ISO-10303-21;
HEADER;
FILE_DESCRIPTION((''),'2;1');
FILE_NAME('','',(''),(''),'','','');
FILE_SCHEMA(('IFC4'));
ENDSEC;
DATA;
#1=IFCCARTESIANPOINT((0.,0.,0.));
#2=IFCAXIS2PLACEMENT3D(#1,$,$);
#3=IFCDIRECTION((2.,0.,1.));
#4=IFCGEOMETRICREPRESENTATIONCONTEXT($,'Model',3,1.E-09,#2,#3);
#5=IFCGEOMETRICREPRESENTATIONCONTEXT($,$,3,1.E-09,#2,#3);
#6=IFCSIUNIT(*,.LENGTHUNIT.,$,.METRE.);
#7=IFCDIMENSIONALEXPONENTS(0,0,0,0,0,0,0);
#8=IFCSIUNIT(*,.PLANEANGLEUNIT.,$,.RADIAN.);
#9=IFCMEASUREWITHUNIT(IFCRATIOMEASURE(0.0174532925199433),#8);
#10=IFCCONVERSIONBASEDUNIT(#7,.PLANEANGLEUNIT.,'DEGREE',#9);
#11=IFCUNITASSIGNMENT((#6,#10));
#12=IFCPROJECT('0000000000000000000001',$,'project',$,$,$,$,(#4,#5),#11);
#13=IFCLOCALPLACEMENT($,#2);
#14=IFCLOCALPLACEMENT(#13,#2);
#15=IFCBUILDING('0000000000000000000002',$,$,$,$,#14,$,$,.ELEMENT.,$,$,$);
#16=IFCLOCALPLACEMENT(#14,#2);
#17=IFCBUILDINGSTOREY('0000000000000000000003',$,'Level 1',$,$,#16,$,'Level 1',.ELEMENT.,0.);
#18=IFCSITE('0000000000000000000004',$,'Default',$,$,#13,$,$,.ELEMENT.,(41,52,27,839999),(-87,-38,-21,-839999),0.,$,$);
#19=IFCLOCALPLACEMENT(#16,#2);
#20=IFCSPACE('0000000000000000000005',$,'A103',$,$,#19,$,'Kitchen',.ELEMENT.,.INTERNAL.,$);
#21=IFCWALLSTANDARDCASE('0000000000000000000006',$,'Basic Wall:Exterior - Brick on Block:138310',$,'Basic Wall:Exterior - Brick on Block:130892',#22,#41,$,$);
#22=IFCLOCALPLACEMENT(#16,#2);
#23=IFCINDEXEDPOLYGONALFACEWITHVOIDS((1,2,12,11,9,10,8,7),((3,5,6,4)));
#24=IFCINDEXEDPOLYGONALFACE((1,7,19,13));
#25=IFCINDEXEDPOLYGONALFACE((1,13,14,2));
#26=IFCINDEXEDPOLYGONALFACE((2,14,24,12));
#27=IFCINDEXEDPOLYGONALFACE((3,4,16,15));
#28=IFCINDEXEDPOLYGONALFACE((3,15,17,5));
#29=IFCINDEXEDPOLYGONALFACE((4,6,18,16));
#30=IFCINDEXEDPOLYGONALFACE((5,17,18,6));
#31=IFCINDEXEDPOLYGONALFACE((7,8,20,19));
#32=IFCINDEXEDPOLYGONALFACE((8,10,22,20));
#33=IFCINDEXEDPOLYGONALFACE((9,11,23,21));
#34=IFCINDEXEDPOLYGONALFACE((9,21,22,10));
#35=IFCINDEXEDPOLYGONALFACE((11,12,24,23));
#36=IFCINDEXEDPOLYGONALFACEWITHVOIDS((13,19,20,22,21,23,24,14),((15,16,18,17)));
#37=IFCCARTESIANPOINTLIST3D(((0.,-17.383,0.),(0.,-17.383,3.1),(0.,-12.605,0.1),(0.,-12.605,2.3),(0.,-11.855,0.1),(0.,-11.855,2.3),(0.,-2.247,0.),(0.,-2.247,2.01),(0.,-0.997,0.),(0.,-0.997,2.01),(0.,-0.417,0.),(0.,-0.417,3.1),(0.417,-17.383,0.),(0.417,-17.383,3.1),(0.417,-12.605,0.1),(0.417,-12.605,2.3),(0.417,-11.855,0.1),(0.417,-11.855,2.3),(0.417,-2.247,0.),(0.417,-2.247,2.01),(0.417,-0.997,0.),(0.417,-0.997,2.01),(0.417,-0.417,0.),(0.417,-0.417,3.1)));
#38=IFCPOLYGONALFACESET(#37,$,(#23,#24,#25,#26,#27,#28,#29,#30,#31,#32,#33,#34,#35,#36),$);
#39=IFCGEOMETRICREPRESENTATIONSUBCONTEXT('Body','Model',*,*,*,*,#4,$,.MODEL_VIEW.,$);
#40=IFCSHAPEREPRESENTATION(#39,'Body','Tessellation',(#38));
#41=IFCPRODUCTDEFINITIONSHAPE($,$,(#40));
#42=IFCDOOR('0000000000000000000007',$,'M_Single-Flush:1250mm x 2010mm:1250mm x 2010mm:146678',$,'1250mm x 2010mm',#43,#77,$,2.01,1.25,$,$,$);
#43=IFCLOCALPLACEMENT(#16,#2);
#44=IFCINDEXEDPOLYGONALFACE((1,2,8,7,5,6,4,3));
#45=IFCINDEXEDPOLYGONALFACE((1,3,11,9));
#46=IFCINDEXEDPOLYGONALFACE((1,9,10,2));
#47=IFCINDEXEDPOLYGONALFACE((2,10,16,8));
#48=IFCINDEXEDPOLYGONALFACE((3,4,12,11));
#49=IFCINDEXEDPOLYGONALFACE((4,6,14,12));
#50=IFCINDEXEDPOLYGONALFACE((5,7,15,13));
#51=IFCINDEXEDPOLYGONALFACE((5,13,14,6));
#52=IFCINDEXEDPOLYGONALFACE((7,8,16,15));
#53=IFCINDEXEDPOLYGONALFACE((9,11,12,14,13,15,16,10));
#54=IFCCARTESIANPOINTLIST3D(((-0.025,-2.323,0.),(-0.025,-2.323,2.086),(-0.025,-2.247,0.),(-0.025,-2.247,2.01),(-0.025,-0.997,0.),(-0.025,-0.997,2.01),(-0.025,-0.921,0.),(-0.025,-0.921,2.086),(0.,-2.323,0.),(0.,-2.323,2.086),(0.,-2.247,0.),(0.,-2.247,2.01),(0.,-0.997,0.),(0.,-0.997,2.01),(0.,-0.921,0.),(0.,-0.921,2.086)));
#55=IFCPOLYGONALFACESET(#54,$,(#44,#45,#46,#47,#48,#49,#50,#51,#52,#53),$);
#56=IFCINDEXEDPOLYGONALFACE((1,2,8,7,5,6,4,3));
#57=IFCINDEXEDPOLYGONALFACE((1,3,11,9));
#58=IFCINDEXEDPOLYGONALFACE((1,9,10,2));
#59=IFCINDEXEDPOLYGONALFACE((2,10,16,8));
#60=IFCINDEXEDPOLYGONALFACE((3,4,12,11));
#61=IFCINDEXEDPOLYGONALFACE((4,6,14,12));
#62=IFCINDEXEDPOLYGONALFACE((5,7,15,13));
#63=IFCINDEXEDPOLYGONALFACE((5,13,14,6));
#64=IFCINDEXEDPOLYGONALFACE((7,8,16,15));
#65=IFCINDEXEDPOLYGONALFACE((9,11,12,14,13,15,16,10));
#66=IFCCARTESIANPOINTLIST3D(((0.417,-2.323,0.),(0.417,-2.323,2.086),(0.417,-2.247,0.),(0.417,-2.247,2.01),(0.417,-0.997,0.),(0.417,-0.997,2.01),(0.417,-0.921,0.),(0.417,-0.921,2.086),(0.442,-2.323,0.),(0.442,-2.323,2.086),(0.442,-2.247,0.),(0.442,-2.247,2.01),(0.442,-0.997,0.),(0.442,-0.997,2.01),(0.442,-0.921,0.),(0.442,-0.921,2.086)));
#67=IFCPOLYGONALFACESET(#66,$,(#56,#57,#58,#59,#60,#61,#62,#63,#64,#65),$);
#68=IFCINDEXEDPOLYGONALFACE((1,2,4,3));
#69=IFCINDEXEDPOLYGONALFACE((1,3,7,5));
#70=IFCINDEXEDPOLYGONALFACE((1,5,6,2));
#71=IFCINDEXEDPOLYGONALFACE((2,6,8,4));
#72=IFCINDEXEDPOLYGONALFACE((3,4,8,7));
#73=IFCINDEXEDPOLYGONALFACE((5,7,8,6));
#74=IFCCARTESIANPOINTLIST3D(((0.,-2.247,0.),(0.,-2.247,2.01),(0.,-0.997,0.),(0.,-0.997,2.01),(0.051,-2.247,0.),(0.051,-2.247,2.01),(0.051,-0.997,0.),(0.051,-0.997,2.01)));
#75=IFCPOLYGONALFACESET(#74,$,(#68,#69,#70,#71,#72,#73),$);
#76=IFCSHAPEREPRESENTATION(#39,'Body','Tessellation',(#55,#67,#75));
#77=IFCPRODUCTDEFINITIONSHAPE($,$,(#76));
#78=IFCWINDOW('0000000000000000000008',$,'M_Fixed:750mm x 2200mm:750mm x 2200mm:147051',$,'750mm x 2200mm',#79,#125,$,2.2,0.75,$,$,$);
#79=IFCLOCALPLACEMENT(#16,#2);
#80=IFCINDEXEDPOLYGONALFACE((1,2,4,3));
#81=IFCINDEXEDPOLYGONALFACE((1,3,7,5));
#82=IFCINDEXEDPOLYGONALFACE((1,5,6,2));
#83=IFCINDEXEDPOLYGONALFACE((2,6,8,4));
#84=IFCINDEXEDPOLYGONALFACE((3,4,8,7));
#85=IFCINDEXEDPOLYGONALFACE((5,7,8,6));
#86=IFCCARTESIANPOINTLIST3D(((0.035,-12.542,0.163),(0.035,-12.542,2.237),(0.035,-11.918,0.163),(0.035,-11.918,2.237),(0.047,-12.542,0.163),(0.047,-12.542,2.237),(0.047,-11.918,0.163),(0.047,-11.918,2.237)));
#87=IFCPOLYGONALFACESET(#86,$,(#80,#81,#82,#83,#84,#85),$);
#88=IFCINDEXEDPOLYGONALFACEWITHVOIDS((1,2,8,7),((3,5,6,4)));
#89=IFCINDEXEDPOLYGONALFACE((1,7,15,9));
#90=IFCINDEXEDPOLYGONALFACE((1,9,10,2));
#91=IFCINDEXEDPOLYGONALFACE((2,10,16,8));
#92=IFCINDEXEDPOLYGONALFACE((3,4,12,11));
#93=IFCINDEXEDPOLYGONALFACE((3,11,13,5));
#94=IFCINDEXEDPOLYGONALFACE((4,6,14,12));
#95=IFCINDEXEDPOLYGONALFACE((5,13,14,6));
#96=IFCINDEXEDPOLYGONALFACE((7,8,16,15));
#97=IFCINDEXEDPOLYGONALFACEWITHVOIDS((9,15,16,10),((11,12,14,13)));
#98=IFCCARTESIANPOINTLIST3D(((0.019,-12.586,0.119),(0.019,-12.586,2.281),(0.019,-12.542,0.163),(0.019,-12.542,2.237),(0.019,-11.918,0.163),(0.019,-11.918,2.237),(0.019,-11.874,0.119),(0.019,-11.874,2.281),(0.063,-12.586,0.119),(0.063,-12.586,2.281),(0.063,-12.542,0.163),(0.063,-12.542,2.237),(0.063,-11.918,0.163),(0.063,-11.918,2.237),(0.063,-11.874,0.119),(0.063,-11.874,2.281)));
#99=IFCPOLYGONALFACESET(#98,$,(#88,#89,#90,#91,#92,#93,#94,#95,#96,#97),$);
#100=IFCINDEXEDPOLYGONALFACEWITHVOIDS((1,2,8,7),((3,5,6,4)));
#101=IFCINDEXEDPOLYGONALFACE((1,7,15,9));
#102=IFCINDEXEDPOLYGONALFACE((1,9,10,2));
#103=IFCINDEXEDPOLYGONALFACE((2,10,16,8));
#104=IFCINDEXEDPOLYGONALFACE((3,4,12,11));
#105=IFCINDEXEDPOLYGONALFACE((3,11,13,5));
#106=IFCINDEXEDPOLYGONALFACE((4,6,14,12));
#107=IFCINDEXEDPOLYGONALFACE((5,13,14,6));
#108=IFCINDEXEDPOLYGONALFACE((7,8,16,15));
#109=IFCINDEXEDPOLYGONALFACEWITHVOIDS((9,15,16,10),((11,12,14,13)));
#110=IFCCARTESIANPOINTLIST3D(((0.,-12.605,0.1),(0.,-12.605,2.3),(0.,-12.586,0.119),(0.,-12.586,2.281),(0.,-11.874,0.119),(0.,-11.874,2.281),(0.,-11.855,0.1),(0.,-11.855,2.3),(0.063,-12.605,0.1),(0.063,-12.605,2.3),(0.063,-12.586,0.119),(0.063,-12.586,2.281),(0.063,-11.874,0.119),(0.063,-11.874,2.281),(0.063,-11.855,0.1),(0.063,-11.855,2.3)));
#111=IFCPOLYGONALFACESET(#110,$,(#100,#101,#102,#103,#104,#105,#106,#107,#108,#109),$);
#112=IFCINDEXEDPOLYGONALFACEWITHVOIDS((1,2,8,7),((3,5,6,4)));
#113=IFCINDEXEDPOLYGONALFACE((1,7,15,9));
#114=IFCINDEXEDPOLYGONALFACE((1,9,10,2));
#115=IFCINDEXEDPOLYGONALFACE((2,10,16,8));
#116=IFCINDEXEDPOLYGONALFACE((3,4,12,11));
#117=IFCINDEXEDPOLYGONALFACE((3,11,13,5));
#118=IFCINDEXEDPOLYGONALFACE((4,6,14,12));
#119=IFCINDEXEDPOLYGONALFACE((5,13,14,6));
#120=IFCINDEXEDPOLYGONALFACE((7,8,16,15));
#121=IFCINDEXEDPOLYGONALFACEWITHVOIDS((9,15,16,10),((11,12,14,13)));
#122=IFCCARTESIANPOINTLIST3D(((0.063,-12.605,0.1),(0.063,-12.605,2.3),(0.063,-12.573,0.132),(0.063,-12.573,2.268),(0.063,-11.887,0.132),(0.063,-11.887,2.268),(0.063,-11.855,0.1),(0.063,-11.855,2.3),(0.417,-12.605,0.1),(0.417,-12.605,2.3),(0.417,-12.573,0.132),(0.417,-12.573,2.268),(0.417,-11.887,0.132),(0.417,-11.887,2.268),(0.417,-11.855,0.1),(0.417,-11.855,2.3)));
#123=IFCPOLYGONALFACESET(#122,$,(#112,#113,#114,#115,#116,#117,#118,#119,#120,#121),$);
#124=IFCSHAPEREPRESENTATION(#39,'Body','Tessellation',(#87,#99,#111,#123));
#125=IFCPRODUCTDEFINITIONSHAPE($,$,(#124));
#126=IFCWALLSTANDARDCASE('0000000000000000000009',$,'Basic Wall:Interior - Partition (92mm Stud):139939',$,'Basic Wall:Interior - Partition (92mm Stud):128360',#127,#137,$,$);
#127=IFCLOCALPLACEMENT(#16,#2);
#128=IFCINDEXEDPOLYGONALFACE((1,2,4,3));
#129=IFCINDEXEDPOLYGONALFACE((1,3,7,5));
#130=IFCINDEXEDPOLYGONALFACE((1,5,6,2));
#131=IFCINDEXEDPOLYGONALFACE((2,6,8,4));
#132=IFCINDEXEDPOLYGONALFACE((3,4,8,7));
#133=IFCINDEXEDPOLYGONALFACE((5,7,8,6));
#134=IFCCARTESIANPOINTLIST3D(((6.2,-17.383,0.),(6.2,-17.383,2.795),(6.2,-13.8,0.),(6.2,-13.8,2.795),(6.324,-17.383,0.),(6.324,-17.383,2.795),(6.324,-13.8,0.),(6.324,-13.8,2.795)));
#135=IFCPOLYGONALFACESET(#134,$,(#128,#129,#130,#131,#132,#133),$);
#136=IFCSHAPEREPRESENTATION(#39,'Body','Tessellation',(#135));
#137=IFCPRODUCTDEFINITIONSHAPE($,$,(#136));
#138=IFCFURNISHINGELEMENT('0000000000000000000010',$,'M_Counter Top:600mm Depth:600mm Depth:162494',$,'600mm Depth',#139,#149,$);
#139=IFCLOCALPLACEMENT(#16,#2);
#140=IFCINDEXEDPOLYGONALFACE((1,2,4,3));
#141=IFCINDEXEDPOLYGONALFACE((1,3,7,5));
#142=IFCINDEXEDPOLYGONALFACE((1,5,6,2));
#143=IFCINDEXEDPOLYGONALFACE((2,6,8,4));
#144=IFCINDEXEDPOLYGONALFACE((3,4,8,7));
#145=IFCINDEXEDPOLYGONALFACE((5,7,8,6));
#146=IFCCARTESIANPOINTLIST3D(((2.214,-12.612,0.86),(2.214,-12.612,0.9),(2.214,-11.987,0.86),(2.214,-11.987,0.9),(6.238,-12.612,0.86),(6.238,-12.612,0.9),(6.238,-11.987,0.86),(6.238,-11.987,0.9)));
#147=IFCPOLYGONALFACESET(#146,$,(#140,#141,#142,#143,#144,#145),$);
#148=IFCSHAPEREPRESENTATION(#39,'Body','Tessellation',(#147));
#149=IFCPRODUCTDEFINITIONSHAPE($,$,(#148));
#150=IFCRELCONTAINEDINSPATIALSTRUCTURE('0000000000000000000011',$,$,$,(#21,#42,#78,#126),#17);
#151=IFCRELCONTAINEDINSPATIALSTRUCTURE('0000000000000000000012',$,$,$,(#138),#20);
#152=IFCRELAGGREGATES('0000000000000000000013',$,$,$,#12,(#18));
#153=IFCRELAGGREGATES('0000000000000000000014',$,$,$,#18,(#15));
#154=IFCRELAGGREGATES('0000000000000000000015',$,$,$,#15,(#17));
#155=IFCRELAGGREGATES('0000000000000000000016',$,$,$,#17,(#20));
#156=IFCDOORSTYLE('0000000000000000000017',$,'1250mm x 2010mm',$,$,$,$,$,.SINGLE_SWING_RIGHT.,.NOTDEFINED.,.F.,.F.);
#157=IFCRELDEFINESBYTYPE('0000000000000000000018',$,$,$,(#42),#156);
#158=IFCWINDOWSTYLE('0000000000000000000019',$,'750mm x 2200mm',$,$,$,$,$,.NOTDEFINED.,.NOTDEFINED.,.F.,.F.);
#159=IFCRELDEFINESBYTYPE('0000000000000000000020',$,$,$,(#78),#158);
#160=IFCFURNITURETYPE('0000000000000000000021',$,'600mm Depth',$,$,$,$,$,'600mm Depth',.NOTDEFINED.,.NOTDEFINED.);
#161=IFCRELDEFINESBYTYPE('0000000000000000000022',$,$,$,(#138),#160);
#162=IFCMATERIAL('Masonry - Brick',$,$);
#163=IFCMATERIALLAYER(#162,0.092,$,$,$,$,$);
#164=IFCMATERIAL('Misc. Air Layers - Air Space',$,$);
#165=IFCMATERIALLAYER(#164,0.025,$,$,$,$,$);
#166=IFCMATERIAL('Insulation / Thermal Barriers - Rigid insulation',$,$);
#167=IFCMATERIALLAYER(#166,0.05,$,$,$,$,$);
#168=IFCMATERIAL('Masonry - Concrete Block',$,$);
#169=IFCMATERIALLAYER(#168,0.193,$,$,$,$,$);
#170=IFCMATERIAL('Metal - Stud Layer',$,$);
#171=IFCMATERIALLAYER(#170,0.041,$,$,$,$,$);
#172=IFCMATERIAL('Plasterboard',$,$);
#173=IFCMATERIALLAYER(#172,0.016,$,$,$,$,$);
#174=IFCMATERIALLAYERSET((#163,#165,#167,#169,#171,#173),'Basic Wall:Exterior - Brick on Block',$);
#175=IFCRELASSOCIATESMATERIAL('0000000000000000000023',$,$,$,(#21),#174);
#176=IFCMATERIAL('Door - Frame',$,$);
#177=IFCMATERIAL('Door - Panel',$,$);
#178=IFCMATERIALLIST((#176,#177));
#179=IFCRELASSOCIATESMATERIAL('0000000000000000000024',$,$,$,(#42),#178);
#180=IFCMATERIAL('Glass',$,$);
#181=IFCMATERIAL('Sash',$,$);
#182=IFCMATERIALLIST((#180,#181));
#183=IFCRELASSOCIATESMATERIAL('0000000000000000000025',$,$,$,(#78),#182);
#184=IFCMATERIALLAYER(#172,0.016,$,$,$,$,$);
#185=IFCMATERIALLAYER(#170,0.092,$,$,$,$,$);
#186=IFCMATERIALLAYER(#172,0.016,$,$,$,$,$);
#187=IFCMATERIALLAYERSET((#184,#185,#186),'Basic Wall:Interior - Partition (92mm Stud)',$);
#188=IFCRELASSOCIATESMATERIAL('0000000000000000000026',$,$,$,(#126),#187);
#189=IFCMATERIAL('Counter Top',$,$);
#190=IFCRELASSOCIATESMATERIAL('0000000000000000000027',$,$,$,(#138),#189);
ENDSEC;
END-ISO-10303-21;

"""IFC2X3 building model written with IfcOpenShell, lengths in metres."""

from ifc_helpers import new_model, entity, si_unit, converted_unit, direction, frame, frame_2d, origin, origin_2d_with_axis, place, context, subcontext, project, spatial, polyline, rectangle, outline, extrude, source, transform, mapped, material, material_list, layer, layer_set, layer_usage, type_object, type_shapes, element, fill, save


model = new_model("IFC2X3")

# Units and contexts
model_context = context("Model", 3, precision=1e-09, world=origin(), true_north=direction((2.0, 0.0, 1.0)))
context_of_model = context(None, 3, precision=1e-09, world=origin(), true_north=direction((2.0, 0.0, 1.0)))
body_context = subcontext(model_context, "Body", "Model", "MODEL_VIEW")
ifc_project = project(units=[si_unit("LENGTHUNIT", "METRE"), converted_unit("PLANEANGLEUNIT", "DEGREE", entity("IfcRatioMeasure", 0.0174532925199433), si_unit("PLANEANGLEUNIT", "RADIAN"), dimensions=[0, 0, 0, 0, 0, 0, 0])], contexts=[model_context, context_of_model])

# Site, building, storey
site_placement = place(None, origin())
site = spatial("IfcSite", under=ifc_project, at=site_placement, Name="Default", CompositionType="ELEMENT", RefLatitude=(41, 52, 27, 839999), RefLongitude=(-87, -38, -21, -839999), RefElevation=0.0)
building_placement = place(site_placement, origin())
building = spatial("IfcBuilding", under=site, at=building_placement, CompositionType="ELEMENT")
storey_placement = place(building_placement, origin())
storey = spatial("IfcBuildingStorey", under=building, at=storey_placement, Name="Level 1", LongName="Level 1", CompositionType="ELEMENT", Elevation=0.0)

# Shared definitions
ifc_material_1 = material(Name="Masonry - Brick")
ifc_layer_1 = layer(ifc_material_1, 0.092)
ifc_material_2 = material(Name="Misc. Air Layers - Air Space")
ifc_layer_2 = layer(ifc_material_2, 0.025)
ifc_material_3 = material(Name="Insulation / Thermal Barriers - Rigid insulation")
ifc_layer_3 = layer(ifc_material_3, 0.05)
ifc_material_4 = material(Name="Masonry - Concrete Block")
ifc_layer_4 = layer(ifc_material_4, 0.193)
ifc_material_5 = material(Name="Metal - Stud Layer")
ifc_layer_5 = layer(ifc_material_5, 0.041)
ifc_material_6 = material(Name="Plasterboard")
ifc_layer_6 = layer(ifc_material_6, 0.016)
ifc_layer_set_1 = layer_set([ifc_layer_1, ifc_layer_2, ifc_layer_3, ifc_layer_4, ifc_layer_5, ifc_layer_6], Name="Basic Wall:Exterior - Brick on Block")
ifc_material_7 = material(Name="Glass")
ifc_material_8 = material(Name="Sash")
ifc_material_9 = material(Name="Door - Frame")
ifc_material_10 = material(Name="Door - Panel")

# Wall, openings, door, window
ifc_layer_usage_1 = layer_usage(ifc_layer_set_1, "AXIS2", "NEGATIVE", 0.2085)
wall_1_placement = place(storey_placement, frame((0.2085, -17.383, 0.0), z_axis=(0.0, 0.0, 1.0), x_axis=(0.0, 1.0, 0.0)))
wall_1 = element("IfcWallStandardCase", 1, at=wall_1_placement, inside=storey, material=ifc_layer_usage_1, Name="Basic Wall:Exterior - Brick on Block:138310", ObjectType="Basic Wall:Exterior - Brick on Block:130892", context=body_context, shape_type="SweptSolid", body=[
    extrude(rectangle(XDim=16.966, YDim=0.417, at=frame_2d((8.483, 0.0), x_axis=(-1.0, 0.0))), origin(), (0.0, 0.0, 1.0), 3.1),
])
opening_1_placement = place(wall_1_placement, frame((15.136, -0.2085, 0.0)))
opening_1 = element("IfcOpeningElement", 2, at=opening_1_placement, cuts=wall_1, ObjectType="Opening", context=body_context, shape_type="SweptSolid", body=[
    extrude(rectangle(XDim=1.25, YDim=2.01, at=frame_2d((1.005, 0.625), x_axis=(0.0, 1.0))), frame((0.0, 0.0, 0.0), z_axis=(0.0, 1.0, 0.0), x_axis=(0.0, 0.0, 1.0)), (0.0, 0.0, 1.0), 0.417),
])
opening_2_placement = place(wall_1_placement, frame((4.778, -0.2085, 0.1)))
opening_2 = element("IfcOpeningElement", 3, at=opening_2_placement, cuts=wall_1, ObjectType="Opening", context=body_context, shape_type="SweptSolid", body=[
    extrude(rectangle(XDim=2.2, YDim=0.75, at=frame_2d((1.1, 0.375), x_axis=(1.0, 0.0))), frame((0.0, 0.0, 0.0), z_axis=(0.0, 1.0, 0.0), x_axis=(0.0, 0.0, 1.0)), (0.0, 0.0, 1.0), 0.417),
])
ifc_material_list_1 = material_list([ifc_material_9, ifc_material_10])
door_style_1 = type_object("IfcDoorStyle", Name="1250mm x 2010mm", ConstructionType="NOTDEFINED", OperationType="SINGLE_SWING_RIGHT", ParameterTakesPrecedence=False, Sizeable=False)
shared_shape_1 = source(origin(), body_context, "Body", "SweptSolid", [
    extrude(outline(polyline([(-0.701, -1.062), (0.701, -1.062), (0.701, 1.024), (0.625, 1.024), (0.625, -0.986), (-0.625, -0.986), (-0.625, 1.024), (-0.701, 1.024), (-0.701, -1.062)])), frame((0.625, 0.417, 1.024), z_axis=(0.0, 1.0, 0.0), x_axis=(1.0, 0.0, 0.0)), (0.0, 0.0, 1.0), 0.025),
    extrude(outline(polyline([(-1.062, -0.701), (1.024, -0.701), (1.024, -0.625), (-0.986, -0.625), (-0.986, 0.625), (1.024, 0.625), (1.024, 0.701), (-1.062, 0.701), (-1.062, -0.701)])), frame((0.625, -0.025, 1.024), z_axis=(0.0, 1.0, 0.0), x_axis=(0.0, 0.0, -1.0)), (0.0, 0.0, 1.0), 0.025),
    extrude(rectangle(XDim=0.051, YDim=1.25, at=frame_2d((0.0, 0.0), x_axis=(1.0, 0.0))), frame((0.625, 0.3915, 0.0), z_axis=(0.0, 0.0, 1.0), x_axis=(0.0, 1.0, 0.0)), (0.0, 0.0, 1.0), 2.01),
])
type_shapes(door_style_1, [shared_shape_1])
door_1_placement = place(opening_1_placement, origin())
door_1 = element("IfcDoor", 4, at=door_1_placement, inside=storey, type_object=door_style_1, material=ifc_material_list_1, Name="M_Single-Flush:1250mm x 2010mm:1250mm x 2010mm:146678", ObjectType="1250mm x 2010mm", OverallHeight=2.01, OverallWidth=1.25, context=body_context, shape_type="MappedRepresentation", body=[
    mapped(shared_shape_1, transform((0.0, 0.0, 0.0), scale=1.0)),
])
fill(opening_1, door_1)
ifc_material_list_2 = material_list([ifc_material_7, ifc_material_8])
window_style_1 = type_object("IfcWindowStyle", Name="750mm x 2200mm", ConstructionType="NOTDEFINED", OperationType="NOTDEFINED", ParameterTakesPrecedence=False, Sizeable=False)
shared_shape_2 = source(origin(), body_context, "Body", "SweptSolid", [
    extrude(rectangle(XDim=0.012, YDim=0.624, at=origin_2d_with_axis()), frame((0.375, 0.376, 0.063), z_axis=(0.0, 0.0, 1.0), x_axis=(0.0, -1.0, 0.0)), (0.0, 0.0, 1.0), 2.074),
    extrude(outline(polyline([(-0.356, -1.081), (0.356, -1.081), (0.356, 1.081), (-0.356, 1.081), (-0.356, -1.081)]), holes=[polyline([(-0.312, -1.037), (-0.312, 1.037), (0.312, 1.037), (0.312, -1.037), (-0.312, -1.037)])]), frame((0.375, 0.354, 1.1), z_axis=(0.0, 1.0, 0.0), x_axis=(1.0, 0.0, 0.0)), (0.0, 0.0, 1.0), 0.044),
    extrude(outline(polyline([(-0.375, -1.1), (0.375, -1.1), (0.375, 1.1), (-0.375, 1.1), (-0.375, -1.1)]), holes=[polyline([(-0.356, -1.081), (-0.356, 1.081), (0.356, 1.081), (0.356, -1.081), (-0.356, -1.081)])]), frame((0.375, 0.354, 1.1), z_axis=(0.0, 1.0, 0.0), x_axis=(1.0, 0.0, 0.0)), (0.0, 0.0, 1.0), 0.063),
    extrude(outline(polyline([(-0.375, -1.1), (0.375, -1.1), (0.375, 1.1), (-0.375, 1.1), (-0.375, -1.1)]), holes=[polyline([(-0.343, -1.068), (-0.343, 1.068), (0.343, 1.068), (0.343, -1.068), (-0.343, -1.068)])]), frame((0.375, 0.0, 1.1), z_axis=(0.0, 1.0, 0.0), x_axis=(1.0, 0.0, 0.0)), (0.0, 0.0, 1.0), 0.354),
])
type_shapes(window_style_1, [shared_shape_2])
window_1_placement = place(opening_2_placement, origin())
window_1 = element("IfcWindow", 5, at=window_1_placement, inside=storey, type_object=window_style_1, material=ifc_material_list_2, Name="M_Fixed:750mm x 2200mm:750mm x 2200mm:147051", ObjectType="750mm x 2200mm", OverallHeight=2.2, OverallWidth=0.75, context=body_context, shape_type="MappedRepresentation", body=[
    mapped(shared_shape_2, transform((0.0, 0.0, 0.0), scale=1.0)),
])
fill(opening_2, window_1)

# Wall
ifc_layer_7 = layer(ifc_material_6, 0.016)
ifc_layer_8 = layer(ifc_material_5, 0.092)
ifc_layer_9 = layer(ifc_material_6, 0.016)
ifc_layer_set_2 = layer_set([ifc_layer_7, ifc_layer_8, ifc_layer_9], Name="Basic Wall:Interior - Partition (92mm Stud)")
ifc_layer_usage_2 = layer_usage(ifc_layer_set_2, "AXIS2", "NEGATIVE", 0.062)
wall_2_placement = place(storey_placement, frame((6.262, -13.8, 0.0), z_axis=(0.0, 0.0, 1.0), x_axis=(0.0, -1.0, 0.0)))
element("IfcWallStandardCase", 6, at=wall_2_placement, inside=storey, material=ifc_layer_usage_2, Name="Basic Wall:Interior - Partition (92mm Stud):139939", ObjectType="Basic Wall:Interior - Partition (92mm Stud):128360", context=body_context, shape_type="SweptSolid", body=[
    extrude(rectangle(XDim=3.583, YDim=0.124, at=frame_2d((1.7915, 0.0), x_axis=(-1.0, 0.0))), origin(), (0.0, 0.0, 1.0), 2.795),
])

# Shared definitions
space_1_placement = place(storey_placement, origin())
space_1 = spatial("IfcSpace", under=storey, at=space_1_placement, Name="A103", LongName="Kitchen", CompositionType="ELEMENT", InteriorOrExteriorSpace="INTERNAL")

# Furnishing element
ifc_material_11 = material(Name="Counter Top")
furniture_type_1 = type_object("IfcFurnitureType", Name="600mm Depth", ElementType="600mm Depth", AssemblyPlace="NOTDEFINED")
shared_shape_3 = source(origin(), body_context, "Body", "SweptSolid", [
    extrude(rectangle(XDim=4.024, YDim=0.625, at=frame_2d((0.0, 0.0), x_axis=(1.0, 0.0))), frame((0.8115, -0.3125, 0.86), z_axis=(0.0, 0.0, 1.0), x_axis=(-1.0, 0.0, 0.0)), (0.0, 0.0, 1.0), 0.04),
])
type_shapes(furniture_type_1, [shared_shape_3])
furnishing_1_placement = place(space_1_placement, frame((5.0375, -12.612, 0.0), z_axis=(0.0, 0.0, 1.0), x_axis=(-1.0, 0.0, 0.0)))
element("IfcFurnishingElement", 7, at=furnishing_1_placement, inside=space_1, type_object=furniture_type_1, material=ifc_material_11, Name="M_Counter Top:600mm Depth:600mm Depth:162494", ObjectType="600mm Depth", context=body_context, shape_type="MappedRepresentation", body=[
    mapped(shared_shape_3, transform((0.0, 0.0, 0.0), scale=1.0)),
])

save(model, "model.ifc")
